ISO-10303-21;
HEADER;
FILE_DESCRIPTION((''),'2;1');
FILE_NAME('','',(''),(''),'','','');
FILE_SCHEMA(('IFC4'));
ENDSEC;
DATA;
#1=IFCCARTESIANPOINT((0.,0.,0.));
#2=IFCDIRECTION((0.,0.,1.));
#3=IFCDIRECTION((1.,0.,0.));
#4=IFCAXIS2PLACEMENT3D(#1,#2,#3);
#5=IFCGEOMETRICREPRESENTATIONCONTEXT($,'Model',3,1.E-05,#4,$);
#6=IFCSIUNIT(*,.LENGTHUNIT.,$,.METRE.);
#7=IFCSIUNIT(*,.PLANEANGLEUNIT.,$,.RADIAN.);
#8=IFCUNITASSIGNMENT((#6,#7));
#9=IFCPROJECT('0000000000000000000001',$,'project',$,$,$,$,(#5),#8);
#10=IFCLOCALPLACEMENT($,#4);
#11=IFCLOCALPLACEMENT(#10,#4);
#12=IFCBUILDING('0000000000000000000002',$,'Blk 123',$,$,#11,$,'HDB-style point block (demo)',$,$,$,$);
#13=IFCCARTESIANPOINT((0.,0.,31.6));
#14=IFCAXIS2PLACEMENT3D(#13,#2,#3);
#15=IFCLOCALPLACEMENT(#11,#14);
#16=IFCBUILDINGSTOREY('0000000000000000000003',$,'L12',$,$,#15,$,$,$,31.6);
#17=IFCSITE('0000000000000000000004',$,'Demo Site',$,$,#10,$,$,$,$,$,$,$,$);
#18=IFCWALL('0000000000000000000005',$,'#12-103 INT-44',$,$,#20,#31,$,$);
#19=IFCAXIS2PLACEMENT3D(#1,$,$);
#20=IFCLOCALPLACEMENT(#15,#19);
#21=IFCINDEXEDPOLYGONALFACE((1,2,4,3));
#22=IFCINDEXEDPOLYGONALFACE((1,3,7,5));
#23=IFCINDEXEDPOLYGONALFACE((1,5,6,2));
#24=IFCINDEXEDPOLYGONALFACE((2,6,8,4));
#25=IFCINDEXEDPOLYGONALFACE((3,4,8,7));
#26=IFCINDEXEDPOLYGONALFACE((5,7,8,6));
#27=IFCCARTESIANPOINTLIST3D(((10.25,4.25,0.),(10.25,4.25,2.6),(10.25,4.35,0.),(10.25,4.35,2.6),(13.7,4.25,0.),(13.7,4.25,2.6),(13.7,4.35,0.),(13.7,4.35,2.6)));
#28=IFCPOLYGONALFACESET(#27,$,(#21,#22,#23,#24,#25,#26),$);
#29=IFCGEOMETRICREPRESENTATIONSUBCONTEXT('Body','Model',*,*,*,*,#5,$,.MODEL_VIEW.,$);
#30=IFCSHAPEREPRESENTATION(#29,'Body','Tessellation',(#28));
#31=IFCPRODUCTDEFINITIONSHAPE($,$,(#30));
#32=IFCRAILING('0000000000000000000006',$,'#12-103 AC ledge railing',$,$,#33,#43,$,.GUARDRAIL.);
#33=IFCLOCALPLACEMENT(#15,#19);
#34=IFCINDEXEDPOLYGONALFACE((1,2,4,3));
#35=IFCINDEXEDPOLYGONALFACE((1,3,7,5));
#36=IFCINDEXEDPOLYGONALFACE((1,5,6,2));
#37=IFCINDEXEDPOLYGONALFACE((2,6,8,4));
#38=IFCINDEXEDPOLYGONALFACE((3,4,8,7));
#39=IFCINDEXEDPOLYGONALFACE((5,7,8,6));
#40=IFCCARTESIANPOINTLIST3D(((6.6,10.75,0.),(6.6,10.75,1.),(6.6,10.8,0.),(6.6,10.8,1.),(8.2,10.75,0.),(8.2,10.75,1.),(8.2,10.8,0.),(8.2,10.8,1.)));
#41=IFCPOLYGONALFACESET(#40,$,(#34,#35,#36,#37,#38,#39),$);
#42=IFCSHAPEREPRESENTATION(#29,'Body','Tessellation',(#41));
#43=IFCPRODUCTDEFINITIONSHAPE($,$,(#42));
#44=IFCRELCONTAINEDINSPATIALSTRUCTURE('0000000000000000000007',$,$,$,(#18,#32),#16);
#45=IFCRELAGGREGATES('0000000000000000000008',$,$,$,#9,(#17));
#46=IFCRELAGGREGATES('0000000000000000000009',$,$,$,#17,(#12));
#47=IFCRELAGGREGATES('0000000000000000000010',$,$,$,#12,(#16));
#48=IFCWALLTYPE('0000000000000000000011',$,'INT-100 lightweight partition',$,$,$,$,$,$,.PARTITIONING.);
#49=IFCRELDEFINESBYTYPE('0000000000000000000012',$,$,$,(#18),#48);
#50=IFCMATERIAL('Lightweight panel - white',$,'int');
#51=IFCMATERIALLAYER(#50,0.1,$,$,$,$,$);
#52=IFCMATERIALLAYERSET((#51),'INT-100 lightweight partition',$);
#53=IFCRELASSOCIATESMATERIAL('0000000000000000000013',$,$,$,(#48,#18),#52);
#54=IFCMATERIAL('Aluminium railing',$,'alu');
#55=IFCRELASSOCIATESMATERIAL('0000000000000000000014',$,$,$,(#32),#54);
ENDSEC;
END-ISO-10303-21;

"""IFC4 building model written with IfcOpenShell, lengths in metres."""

from ifc_helpers import new_model, si_unit, frame, origin, origin_with_axes, place, context, subcontext, project, spatial, polyline, indexed_curve, outline, extrude, material, layer, layer_set, layer_usage, type_object, element, save


model = new_model("IFC4")

# Units and contexts
model_context = context("Model", 3, precision=1e-05, world=origin_with_axes())
body_context = subcontext(model_context, "Body", "Model", "MODEL_VIEW")
ifc_project = project(units=[si_unit("LENGTHUNIT", "METRE"), si_unit("PLANEANGLEUNIT", "RADIAN")], contexts=[model_context])

# Site, building, storey
site_placement = place(None, origin_with_axes())
site = spatial("IfcSite", under=ifc_project, at=site_placement, Name="Demo Site")
building_placement = place(site_placement, origin_with_axes())
building = spatial("IfcBuilding", under=site, at=building_placement, Name="Blk 123", LongName="HDB-style point block (demo)")
storey_placement = place(building_placement, frame((0.0, 0.0, 31.6), z_axis=(0.0, 0.0, 1.0), x_axis=(1.0, 0.0, 0.0)))
storey = spatial("IfcBuildingStorey", under=building, at=storey_placement, Name="L12", Elevation=31.6)

# Wall
ifc_material_1 = material(Name="Lightweight panel - white", Category="int")
ifc_layer_1 = layer(ifc_material_1, 0.1)
ifc_layer_set_1 = layer_set([ifc_layer_1], Name="INT-100 lightweight partition")
ifc_layer_usage_1 = layer_usage(ifc_layer_set_1, "AXIS2", "POSITIVE", -0.05)
wall_type_1 = type_object("IfcWallType", Name="INT-100 lightweight partition", PredefinedType="PARTITIONING", material=ifc_layer_set_1)
wall_1_placement = place(storey_placement, frame((10.25, 4.3, 0.0), z_axis=(0.0, 0.0, 1.0), x_axis=(1.0, 0.0, 0.0)))
element("IfcWall", 1, at=wall_1_placement, inside=storey, type_object=wall_type_1, material=ifc_layer_usage_1, Name="#12-103 INT-44", context=body_context, shape_type="SweptSolid", body=[
    extrude(outline(indexed_curve([(0.0, 0.0), (0.0, 0.1), (3.45, 0.1), (3.45, 0.0), (0.0, 0.0)], self_intersect=False)), frame((0.0, -0.05, 0.0), z_axis=(0.0, 0.0, 1.0), x_axis=(1.0, 0.0, 0.0)), (0.0, 0.0, 1.0), 2.6),
])

# Railing
ifc_material_2 = material(Name="Aluminium railing", Category="alu")
railing_placement = place(storey_placement, frame((7.4, 10.775, 0.0), z_axis=(0.0, 0.0, 1.0), x_axis=(1.0, 0.0, 0.0)))
element("IfcRailing", 2, at=railing_placement, inside=storey, material=ifc_material_2, Name="#12-103 AC ledge railing", PredefinedType="GUARDRAIL", context=body_context, shape_type="SweptSolid", body=[
    extrude(outline(polyline([(0.8, -0.025), (0.8, 0.025), (-0.8, 0.025), (-0.8, -0.025), (0.8, -0.025)])), origin(), (0.0, 0.0, 1.0), 1.0),
])

save(model, "model.ifc")
